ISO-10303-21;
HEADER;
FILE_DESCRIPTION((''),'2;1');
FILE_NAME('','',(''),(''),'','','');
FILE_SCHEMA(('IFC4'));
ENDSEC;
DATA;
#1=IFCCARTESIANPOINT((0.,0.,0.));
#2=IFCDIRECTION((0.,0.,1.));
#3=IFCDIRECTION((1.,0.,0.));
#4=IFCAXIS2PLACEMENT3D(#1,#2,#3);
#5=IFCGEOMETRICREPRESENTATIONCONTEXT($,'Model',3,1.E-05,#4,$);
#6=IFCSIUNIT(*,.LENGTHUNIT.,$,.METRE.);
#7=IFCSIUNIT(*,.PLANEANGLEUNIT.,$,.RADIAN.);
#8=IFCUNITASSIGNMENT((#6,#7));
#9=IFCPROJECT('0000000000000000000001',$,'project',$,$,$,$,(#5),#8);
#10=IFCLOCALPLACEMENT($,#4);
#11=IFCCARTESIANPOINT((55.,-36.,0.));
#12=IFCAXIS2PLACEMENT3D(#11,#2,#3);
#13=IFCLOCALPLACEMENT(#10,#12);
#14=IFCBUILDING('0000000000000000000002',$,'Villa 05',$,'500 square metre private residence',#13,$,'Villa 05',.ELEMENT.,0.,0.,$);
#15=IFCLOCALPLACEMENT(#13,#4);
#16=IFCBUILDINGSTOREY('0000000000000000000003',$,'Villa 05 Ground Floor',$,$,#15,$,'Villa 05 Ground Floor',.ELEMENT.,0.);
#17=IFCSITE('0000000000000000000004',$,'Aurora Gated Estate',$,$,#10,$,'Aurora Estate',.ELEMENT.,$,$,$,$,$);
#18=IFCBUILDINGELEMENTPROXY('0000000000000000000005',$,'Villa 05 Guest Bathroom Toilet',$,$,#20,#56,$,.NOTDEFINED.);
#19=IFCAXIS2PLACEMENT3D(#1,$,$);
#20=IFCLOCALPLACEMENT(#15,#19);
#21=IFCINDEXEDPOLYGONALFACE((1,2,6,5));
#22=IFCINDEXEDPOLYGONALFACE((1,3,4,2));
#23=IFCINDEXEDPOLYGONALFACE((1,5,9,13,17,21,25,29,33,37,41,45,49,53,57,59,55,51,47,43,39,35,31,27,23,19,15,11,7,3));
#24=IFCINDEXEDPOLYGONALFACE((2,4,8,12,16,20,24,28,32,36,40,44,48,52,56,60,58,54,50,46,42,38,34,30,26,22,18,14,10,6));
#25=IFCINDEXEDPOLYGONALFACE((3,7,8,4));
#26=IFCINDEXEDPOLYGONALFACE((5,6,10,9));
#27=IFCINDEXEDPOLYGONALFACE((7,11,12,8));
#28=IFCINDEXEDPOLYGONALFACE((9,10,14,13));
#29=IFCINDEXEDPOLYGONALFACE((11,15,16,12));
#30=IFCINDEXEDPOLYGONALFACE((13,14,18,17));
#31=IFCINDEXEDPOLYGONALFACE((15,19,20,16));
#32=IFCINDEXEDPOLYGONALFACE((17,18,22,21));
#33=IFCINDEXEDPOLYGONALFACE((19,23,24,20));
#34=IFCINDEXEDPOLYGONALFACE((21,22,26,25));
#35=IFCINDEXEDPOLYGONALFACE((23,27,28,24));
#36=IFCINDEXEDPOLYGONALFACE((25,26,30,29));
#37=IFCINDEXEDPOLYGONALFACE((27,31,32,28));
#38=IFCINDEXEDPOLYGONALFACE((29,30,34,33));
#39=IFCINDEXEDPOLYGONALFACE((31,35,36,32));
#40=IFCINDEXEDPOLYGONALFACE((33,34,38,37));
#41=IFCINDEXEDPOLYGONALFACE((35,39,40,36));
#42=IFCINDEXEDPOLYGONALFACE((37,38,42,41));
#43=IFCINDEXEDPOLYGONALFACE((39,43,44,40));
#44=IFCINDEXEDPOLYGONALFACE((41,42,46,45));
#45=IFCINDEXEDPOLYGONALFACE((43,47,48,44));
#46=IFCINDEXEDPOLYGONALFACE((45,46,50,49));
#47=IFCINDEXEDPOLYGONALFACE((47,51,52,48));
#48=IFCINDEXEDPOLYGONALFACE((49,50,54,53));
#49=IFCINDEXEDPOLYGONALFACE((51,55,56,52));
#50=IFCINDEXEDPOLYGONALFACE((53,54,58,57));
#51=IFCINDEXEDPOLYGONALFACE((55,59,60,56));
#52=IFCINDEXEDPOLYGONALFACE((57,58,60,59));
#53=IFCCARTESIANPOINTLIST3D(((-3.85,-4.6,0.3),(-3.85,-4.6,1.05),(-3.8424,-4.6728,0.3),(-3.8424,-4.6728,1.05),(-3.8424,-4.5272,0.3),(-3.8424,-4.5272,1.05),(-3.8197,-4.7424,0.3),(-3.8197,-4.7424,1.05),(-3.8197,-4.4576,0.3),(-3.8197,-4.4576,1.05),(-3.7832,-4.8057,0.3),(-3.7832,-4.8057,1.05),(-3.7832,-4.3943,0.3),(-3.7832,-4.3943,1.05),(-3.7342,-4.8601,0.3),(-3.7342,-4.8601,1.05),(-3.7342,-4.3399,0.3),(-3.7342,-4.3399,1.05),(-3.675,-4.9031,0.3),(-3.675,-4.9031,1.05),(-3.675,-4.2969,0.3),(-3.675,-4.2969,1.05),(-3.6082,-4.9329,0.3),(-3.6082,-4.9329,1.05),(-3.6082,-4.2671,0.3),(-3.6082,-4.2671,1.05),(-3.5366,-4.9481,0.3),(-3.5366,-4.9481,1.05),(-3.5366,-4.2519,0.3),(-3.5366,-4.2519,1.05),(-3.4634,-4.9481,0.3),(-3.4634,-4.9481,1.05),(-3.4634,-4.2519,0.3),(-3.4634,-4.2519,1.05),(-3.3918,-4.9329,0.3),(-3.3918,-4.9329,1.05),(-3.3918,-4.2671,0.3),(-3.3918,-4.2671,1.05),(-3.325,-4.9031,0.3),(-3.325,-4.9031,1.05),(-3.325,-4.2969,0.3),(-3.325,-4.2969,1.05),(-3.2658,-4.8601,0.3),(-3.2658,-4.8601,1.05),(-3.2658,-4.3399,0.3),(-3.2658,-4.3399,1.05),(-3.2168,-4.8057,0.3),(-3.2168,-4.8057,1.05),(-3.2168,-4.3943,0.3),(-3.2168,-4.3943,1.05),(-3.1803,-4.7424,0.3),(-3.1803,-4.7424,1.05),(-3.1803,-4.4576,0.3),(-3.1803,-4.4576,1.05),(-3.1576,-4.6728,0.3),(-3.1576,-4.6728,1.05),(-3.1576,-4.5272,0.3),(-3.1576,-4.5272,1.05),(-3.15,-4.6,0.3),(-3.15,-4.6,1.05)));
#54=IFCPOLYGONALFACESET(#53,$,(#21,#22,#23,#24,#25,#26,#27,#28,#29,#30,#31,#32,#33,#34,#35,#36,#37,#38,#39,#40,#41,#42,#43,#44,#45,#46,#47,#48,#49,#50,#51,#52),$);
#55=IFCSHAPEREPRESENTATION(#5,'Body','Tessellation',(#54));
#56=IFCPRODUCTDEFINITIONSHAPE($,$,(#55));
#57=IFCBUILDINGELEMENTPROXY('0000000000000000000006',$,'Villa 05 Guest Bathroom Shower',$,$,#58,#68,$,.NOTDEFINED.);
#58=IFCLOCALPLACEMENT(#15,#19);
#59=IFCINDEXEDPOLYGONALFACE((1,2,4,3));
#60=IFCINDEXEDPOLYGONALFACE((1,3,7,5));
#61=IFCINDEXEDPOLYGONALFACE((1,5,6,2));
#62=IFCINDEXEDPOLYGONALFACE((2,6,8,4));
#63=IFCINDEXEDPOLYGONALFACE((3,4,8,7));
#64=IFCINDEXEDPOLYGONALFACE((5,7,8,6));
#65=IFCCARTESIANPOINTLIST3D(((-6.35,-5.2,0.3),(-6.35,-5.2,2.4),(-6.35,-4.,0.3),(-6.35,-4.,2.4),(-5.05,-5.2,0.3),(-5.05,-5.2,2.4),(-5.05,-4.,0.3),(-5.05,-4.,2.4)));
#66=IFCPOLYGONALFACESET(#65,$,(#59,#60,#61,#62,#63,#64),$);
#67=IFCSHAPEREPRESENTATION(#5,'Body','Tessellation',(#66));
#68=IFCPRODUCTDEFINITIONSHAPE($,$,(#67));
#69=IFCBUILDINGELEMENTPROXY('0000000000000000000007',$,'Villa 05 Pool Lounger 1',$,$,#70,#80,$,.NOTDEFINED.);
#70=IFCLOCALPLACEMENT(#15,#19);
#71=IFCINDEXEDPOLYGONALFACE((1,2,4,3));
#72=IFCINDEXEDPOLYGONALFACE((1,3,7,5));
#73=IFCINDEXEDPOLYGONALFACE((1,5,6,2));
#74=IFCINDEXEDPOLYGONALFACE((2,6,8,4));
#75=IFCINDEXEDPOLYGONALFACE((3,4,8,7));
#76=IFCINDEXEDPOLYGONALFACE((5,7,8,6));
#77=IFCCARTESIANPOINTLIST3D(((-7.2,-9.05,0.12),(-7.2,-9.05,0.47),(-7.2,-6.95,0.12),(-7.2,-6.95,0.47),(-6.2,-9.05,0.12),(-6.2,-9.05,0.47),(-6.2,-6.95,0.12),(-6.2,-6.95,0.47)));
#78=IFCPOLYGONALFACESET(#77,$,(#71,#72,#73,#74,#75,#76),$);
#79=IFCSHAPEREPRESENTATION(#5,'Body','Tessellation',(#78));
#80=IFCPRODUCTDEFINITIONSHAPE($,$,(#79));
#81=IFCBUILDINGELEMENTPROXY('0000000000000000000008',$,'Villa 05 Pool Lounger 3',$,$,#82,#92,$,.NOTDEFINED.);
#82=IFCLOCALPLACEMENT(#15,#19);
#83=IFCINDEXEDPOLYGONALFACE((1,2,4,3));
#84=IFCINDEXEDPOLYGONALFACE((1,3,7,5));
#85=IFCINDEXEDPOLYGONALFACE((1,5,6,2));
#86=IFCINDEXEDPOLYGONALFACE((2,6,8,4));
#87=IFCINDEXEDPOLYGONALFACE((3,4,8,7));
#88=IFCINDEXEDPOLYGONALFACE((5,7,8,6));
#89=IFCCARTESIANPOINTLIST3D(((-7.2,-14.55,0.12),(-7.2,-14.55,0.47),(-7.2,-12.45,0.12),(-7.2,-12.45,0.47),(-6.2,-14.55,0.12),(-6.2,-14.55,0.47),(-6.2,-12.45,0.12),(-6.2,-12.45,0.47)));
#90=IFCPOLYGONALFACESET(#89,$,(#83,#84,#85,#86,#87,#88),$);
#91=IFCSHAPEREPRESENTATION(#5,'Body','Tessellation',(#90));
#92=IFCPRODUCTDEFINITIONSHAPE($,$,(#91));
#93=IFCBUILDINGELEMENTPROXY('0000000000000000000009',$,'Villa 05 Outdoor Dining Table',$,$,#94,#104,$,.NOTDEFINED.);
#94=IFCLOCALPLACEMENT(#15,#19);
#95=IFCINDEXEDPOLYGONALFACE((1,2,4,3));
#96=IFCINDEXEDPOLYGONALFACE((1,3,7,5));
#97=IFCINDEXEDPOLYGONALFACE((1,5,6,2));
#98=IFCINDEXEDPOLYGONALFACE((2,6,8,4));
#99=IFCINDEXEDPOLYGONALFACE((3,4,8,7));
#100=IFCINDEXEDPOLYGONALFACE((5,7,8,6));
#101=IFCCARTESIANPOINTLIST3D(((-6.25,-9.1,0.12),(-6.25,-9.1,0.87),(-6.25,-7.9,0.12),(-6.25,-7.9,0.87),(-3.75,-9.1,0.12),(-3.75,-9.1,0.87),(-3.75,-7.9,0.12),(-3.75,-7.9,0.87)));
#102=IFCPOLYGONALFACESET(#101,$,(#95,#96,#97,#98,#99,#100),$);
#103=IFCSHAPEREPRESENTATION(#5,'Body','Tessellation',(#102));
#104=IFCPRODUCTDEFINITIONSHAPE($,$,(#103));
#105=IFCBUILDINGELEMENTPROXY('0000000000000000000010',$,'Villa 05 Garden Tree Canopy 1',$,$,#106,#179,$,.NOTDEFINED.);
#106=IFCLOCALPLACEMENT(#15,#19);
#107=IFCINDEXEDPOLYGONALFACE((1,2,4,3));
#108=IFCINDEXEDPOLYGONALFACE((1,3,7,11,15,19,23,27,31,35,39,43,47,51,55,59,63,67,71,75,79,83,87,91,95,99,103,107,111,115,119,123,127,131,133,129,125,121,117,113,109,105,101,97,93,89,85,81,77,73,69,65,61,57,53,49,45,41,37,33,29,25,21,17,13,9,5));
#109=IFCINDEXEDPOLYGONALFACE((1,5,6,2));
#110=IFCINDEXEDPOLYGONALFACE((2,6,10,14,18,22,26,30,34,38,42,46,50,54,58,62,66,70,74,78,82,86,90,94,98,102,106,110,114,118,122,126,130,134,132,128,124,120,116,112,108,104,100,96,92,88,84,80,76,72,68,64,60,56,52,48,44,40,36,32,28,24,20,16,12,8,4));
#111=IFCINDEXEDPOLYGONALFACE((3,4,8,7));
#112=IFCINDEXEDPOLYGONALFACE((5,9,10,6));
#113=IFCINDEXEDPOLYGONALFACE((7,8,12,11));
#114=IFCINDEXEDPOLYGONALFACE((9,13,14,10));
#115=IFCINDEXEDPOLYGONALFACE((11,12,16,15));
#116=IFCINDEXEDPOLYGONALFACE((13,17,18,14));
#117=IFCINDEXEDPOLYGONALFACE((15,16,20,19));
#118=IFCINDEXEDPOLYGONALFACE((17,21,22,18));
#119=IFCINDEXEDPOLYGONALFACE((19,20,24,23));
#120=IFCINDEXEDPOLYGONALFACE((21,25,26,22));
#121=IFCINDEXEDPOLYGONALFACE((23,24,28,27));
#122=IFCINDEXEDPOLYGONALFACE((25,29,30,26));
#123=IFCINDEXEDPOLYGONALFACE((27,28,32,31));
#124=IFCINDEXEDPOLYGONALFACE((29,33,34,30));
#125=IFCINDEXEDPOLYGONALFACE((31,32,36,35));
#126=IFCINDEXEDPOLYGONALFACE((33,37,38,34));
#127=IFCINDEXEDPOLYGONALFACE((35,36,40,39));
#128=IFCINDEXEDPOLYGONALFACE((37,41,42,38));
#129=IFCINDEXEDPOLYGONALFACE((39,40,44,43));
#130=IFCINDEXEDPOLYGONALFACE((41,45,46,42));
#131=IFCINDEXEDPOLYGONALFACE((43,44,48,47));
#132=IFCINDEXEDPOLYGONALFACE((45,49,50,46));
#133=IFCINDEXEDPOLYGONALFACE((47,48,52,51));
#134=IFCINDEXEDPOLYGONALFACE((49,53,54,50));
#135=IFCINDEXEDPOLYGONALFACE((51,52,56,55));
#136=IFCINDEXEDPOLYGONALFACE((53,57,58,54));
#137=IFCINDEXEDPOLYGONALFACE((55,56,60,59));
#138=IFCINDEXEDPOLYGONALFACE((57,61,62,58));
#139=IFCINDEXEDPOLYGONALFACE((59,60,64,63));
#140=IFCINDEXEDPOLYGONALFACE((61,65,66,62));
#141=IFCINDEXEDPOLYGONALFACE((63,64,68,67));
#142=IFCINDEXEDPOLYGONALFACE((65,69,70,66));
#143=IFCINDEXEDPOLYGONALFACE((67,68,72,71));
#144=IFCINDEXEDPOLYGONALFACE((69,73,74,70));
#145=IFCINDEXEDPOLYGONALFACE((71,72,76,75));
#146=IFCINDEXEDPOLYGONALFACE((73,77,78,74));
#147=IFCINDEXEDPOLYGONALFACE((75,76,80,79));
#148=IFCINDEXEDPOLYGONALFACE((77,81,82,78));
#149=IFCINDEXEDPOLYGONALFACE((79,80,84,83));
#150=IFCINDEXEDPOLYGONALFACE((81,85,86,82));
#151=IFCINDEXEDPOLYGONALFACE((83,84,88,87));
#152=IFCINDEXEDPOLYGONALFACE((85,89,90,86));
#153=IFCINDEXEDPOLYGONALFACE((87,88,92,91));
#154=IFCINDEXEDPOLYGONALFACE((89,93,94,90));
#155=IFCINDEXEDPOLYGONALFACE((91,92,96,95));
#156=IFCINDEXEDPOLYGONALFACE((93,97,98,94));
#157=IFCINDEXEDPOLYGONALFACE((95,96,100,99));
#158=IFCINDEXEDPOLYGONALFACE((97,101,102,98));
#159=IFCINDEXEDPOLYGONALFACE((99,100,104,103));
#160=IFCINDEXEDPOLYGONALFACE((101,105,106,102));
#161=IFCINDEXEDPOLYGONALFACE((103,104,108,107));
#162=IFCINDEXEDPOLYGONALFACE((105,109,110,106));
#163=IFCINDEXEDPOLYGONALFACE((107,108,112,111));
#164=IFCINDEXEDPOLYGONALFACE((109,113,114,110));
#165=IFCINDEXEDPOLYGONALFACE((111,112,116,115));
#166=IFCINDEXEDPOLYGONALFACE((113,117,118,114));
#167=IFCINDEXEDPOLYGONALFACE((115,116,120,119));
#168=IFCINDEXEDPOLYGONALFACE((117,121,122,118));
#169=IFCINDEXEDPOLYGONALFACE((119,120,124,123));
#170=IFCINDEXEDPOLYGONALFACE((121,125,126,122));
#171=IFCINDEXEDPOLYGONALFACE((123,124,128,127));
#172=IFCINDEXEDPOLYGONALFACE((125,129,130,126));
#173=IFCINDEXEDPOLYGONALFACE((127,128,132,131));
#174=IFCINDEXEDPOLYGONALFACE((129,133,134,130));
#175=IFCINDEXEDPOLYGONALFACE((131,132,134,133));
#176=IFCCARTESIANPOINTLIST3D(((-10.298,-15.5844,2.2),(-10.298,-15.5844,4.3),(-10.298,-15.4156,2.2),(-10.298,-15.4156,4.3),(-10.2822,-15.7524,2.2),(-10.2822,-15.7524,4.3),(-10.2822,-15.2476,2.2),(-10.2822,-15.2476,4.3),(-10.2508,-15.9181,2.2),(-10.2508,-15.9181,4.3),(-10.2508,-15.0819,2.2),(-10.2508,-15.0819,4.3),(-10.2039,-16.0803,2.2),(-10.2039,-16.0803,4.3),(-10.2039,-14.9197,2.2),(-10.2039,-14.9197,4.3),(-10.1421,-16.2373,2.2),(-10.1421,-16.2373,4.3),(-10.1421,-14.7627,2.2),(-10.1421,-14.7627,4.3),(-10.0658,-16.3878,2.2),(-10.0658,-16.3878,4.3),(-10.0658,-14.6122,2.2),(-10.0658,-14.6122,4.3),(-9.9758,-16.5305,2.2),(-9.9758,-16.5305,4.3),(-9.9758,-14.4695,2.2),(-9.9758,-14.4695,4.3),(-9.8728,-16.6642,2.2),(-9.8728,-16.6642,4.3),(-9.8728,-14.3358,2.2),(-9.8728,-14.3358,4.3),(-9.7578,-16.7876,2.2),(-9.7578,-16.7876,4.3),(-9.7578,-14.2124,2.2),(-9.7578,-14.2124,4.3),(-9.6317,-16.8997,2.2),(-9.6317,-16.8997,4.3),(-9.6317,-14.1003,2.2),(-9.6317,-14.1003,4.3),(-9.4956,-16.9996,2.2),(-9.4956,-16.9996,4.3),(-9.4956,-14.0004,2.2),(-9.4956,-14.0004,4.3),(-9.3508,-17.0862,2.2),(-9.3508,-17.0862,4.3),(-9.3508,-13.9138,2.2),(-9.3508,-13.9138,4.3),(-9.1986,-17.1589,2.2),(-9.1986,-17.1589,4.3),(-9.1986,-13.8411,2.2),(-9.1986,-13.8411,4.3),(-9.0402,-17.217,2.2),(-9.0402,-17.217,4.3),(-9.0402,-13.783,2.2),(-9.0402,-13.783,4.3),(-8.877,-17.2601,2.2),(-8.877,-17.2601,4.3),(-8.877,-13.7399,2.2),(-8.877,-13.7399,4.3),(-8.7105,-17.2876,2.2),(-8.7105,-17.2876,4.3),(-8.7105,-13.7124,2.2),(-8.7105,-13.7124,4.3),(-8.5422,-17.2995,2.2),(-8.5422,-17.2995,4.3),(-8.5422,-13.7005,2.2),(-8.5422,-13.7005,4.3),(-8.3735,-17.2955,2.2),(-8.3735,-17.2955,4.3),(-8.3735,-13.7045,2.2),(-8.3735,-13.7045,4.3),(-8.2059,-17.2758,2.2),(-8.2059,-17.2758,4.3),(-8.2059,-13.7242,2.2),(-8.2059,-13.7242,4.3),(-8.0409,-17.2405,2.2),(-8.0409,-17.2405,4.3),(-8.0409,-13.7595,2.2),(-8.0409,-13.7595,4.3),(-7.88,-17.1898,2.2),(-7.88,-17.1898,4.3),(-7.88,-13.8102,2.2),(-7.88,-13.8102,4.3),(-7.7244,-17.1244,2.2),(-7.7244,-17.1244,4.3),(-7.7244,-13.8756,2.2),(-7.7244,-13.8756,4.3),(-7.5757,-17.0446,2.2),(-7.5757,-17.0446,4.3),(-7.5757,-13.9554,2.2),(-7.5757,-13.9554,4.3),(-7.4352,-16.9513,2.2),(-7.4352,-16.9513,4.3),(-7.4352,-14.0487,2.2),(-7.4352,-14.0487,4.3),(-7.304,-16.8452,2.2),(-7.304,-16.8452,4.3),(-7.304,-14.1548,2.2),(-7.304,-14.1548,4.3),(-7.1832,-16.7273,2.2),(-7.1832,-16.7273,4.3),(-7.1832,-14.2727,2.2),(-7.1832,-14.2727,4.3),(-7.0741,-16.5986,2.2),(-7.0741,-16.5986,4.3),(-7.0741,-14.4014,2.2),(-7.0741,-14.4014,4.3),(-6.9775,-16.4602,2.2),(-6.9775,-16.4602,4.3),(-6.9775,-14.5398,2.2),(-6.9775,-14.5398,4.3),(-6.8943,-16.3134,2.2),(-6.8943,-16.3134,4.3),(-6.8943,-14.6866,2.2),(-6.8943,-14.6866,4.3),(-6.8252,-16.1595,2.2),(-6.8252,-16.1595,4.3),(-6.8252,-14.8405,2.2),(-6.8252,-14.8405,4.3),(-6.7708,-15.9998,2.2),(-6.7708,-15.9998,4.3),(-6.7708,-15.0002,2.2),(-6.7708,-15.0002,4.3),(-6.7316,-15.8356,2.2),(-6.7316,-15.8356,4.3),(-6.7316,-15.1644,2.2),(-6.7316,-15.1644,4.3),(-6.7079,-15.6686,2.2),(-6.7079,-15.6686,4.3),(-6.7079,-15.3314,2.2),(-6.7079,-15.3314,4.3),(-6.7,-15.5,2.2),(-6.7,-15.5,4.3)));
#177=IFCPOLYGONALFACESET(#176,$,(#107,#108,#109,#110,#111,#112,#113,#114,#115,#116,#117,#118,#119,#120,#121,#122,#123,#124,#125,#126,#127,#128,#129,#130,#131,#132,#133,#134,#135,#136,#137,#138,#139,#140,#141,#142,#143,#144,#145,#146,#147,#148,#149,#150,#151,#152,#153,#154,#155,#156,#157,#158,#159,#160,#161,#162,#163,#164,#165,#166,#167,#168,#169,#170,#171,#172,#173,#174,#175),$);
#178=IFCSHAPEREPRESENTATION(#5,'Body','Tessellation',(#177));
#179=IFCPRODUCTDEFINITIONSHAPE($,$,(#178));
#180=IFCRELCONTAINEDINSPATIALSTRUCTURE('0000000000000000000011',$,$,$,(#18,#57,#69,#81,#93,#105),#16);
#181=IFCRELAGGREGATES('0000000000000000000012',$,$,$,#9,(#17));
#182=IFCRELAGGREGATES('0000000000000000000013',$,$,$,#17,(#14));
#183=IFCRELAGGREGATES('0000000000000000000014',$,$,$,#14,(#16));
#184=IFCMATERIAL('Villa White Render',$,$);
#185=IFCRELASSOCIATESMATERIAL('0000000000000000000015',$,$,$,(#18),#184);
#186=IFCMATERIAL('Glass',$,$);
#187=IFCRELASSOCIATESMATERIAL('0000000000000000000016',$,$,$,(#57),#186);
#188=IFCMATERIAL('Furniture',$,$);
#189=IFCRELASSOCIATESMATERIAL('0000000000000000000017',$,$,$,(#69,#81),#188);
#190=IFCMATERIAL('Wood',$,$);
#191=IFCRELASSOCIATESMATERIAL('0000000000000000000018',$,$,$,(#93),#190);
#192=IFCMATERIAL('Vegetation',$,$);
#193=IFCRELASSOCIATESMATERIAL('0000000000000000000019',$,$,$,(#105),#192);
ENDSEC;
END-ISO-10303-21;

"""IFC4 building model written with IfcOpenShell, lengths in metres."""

from ifc_helpers import new_model, si_unit, frame, origin_with_axes, origin_2d_with_axis, place, context, project, spatial, rectangle, circle, extrude, material, element, save


model = new_model("IFC4")

# Units and contexts
model_context = context("Model", 3, precision=1e-05, world=origin_with_axes())
ifc_project = project(units=[si_unit("LENGTHUNIT", "METRE"), si_unit("PLANEANGLEUNIT", "RADIAN")], contexts=[model_context])

# Site, building, storey
site_placement = place(None, origin_with_axes())
site = spatial("IfcSite", under=ifc_project, at=site_placement, Name="Aurora Gated Estate", LongName="Aurora Estate", CompositionType="ELEMENT")
building_placement = place(site_placement, frame((55.0, -36.0, 0.0), z_axis=(0.0, 0.0, 1.0), x_axis=(1.0, 0.0, 0.0)))
building = spatial("IfcBuilding", under=site, at=building_placement, Name="Villa 05", ObjectType="500 square metre private residence", LongName="Villa 05", CompositionType="ELEMENT", ElevationOfRefHeight=0.0, ElevationOfTerrain=0.0)
storey_placement = place(building_placement, origin_with_axes())
storey = spatial("IfcBuildingStorey", under=building, at=storey_placement, Name="Villa 05 Ground Floor", LongName="Villa 05 Ground Floor", CompositionType="ELEMENT", Elevation=0.0)

# Shared definitions
ifc_material_1 = material(Name="Wood")

# Building element proxies
ifc_material_2 = material(Name="Furniture")
ifc_material_3 = material(Name="Villa White Render")
proxy_1_placement = place(storey_placement, frame((-3.5, -4.6, 0.3), z_axis=(0.0, 0.0, 1.0), x_axis=(1.0, 0.0, 0.0)))
element("IfcBuildingElementProxy", 1, at=proxy_1_placement, inside=storey, material=ifc_material_3, Name="Villa 05 Guest Bathroom Toilet", PredefinedType="NOTDEFINED", context=model_context, shape_type="SweptSolid", body=[
    extrude(circle(Radius=0.35, at=origin_2d_with_axis()), origin_with_axes(), (0.0, 0.0, 1.0), 0.75),
])
ifc_material_4 = material(Name="Glass")
proxy_2_placement = place(storey_placement, frame((-5.7, -4.6, 0.3), z_axis=(0.0, 0.0, 1.0), x_axis=(1.0, 0.0, 0.0)))
element("IfcBuildingElementProxy", 2, at=proxy_2_placement, inside=storey, material=ifc_material_4, Name="Villa 05 Guest Bathroom Shower", PredefinedType="NOTDEFINED", context=model_context, shape_type="SweptSolid", body=[
    extrude(rectangle(XDim=1.3, YDim=1.2, at=origin_2d_with_axis()), origin_with_axes(), (0.0, 0.0, 1.0), 2.1),
])
for number, where, z_axis, x_axis, name in (
    (3, (-6.7, -8.0, 0.12), (0.0, 0.0, 1.0), (1.0, 0.0, 0.0), "Villa 05 Pool Lounger 1"),
    (4, (-6.7, -13.5, 0.12), (0.0, 0.0, 1.0), (1.0, 0.0, 0.0), "Villa 05 Pool Lounger 3"),
):
    element("IfcBuildingElementProxy", number, at=place(storey_placement, frame(where, z_axis=z_axis, x_axis=x_axis)), inside=storey, material=ifc_material_2, Name=name, PredefinedType="NOTDEFINED", context=model_context, shape_type="SweptSolid", body=[
        extrude(rectangle(XDim=1.0, YDim=2.1, at=origin_2d_with_axis()), origin_with_axes(), (0.0, 0.0, 1.0), 0.35),
    ])
proxy_3_placement = place(storey_placement, frame((-5.0, -8.5, 0.12), z_axis=(0.0, 0.0, 1.0), x_axis=(1.0, 0.0, 0.0)))
element("IfcBuildingElementProxy", 5, at=proxy_3_placement, inside=storey, material=ifc_material_1, Name="Villa 05 Outdoor Dining Table", PredefinedType="NOTDEFINED", context=model_context, shape_type="SweptSolid", body=[
    extrude(rectangle(XDim=2.5, YDim=1.2, at=origin_2d_with_axis()), origin_with_axes(), (0.0, 0.0, 1.0), 0.75),
])
ifc_material_5 = material(Name="Vegetation")
proxy_4_placement = place(storey_placement, frame((-8.5, -15.5, 2.2), z_axis=(0.0, 0.0, 1.0), x_axis=(1.0, 0.0, 0.0)))
element("IfcBuildingElementProxy", 6, at=proxy_4_placement, inside=storey, material=ifc_material_5, Name="Villa 05 Garden Tree Canopy 1", PredefinedType="NOTDEFINED", context=model_context, shape_type="SweptSolid", body=[
    extrude(circle(Radius=1.8, at=origin_2d_with_axis()), origin_with_axes(), (0.0, 0.0, 1.0), 2.1),
])

save(model, "model.ifc")
